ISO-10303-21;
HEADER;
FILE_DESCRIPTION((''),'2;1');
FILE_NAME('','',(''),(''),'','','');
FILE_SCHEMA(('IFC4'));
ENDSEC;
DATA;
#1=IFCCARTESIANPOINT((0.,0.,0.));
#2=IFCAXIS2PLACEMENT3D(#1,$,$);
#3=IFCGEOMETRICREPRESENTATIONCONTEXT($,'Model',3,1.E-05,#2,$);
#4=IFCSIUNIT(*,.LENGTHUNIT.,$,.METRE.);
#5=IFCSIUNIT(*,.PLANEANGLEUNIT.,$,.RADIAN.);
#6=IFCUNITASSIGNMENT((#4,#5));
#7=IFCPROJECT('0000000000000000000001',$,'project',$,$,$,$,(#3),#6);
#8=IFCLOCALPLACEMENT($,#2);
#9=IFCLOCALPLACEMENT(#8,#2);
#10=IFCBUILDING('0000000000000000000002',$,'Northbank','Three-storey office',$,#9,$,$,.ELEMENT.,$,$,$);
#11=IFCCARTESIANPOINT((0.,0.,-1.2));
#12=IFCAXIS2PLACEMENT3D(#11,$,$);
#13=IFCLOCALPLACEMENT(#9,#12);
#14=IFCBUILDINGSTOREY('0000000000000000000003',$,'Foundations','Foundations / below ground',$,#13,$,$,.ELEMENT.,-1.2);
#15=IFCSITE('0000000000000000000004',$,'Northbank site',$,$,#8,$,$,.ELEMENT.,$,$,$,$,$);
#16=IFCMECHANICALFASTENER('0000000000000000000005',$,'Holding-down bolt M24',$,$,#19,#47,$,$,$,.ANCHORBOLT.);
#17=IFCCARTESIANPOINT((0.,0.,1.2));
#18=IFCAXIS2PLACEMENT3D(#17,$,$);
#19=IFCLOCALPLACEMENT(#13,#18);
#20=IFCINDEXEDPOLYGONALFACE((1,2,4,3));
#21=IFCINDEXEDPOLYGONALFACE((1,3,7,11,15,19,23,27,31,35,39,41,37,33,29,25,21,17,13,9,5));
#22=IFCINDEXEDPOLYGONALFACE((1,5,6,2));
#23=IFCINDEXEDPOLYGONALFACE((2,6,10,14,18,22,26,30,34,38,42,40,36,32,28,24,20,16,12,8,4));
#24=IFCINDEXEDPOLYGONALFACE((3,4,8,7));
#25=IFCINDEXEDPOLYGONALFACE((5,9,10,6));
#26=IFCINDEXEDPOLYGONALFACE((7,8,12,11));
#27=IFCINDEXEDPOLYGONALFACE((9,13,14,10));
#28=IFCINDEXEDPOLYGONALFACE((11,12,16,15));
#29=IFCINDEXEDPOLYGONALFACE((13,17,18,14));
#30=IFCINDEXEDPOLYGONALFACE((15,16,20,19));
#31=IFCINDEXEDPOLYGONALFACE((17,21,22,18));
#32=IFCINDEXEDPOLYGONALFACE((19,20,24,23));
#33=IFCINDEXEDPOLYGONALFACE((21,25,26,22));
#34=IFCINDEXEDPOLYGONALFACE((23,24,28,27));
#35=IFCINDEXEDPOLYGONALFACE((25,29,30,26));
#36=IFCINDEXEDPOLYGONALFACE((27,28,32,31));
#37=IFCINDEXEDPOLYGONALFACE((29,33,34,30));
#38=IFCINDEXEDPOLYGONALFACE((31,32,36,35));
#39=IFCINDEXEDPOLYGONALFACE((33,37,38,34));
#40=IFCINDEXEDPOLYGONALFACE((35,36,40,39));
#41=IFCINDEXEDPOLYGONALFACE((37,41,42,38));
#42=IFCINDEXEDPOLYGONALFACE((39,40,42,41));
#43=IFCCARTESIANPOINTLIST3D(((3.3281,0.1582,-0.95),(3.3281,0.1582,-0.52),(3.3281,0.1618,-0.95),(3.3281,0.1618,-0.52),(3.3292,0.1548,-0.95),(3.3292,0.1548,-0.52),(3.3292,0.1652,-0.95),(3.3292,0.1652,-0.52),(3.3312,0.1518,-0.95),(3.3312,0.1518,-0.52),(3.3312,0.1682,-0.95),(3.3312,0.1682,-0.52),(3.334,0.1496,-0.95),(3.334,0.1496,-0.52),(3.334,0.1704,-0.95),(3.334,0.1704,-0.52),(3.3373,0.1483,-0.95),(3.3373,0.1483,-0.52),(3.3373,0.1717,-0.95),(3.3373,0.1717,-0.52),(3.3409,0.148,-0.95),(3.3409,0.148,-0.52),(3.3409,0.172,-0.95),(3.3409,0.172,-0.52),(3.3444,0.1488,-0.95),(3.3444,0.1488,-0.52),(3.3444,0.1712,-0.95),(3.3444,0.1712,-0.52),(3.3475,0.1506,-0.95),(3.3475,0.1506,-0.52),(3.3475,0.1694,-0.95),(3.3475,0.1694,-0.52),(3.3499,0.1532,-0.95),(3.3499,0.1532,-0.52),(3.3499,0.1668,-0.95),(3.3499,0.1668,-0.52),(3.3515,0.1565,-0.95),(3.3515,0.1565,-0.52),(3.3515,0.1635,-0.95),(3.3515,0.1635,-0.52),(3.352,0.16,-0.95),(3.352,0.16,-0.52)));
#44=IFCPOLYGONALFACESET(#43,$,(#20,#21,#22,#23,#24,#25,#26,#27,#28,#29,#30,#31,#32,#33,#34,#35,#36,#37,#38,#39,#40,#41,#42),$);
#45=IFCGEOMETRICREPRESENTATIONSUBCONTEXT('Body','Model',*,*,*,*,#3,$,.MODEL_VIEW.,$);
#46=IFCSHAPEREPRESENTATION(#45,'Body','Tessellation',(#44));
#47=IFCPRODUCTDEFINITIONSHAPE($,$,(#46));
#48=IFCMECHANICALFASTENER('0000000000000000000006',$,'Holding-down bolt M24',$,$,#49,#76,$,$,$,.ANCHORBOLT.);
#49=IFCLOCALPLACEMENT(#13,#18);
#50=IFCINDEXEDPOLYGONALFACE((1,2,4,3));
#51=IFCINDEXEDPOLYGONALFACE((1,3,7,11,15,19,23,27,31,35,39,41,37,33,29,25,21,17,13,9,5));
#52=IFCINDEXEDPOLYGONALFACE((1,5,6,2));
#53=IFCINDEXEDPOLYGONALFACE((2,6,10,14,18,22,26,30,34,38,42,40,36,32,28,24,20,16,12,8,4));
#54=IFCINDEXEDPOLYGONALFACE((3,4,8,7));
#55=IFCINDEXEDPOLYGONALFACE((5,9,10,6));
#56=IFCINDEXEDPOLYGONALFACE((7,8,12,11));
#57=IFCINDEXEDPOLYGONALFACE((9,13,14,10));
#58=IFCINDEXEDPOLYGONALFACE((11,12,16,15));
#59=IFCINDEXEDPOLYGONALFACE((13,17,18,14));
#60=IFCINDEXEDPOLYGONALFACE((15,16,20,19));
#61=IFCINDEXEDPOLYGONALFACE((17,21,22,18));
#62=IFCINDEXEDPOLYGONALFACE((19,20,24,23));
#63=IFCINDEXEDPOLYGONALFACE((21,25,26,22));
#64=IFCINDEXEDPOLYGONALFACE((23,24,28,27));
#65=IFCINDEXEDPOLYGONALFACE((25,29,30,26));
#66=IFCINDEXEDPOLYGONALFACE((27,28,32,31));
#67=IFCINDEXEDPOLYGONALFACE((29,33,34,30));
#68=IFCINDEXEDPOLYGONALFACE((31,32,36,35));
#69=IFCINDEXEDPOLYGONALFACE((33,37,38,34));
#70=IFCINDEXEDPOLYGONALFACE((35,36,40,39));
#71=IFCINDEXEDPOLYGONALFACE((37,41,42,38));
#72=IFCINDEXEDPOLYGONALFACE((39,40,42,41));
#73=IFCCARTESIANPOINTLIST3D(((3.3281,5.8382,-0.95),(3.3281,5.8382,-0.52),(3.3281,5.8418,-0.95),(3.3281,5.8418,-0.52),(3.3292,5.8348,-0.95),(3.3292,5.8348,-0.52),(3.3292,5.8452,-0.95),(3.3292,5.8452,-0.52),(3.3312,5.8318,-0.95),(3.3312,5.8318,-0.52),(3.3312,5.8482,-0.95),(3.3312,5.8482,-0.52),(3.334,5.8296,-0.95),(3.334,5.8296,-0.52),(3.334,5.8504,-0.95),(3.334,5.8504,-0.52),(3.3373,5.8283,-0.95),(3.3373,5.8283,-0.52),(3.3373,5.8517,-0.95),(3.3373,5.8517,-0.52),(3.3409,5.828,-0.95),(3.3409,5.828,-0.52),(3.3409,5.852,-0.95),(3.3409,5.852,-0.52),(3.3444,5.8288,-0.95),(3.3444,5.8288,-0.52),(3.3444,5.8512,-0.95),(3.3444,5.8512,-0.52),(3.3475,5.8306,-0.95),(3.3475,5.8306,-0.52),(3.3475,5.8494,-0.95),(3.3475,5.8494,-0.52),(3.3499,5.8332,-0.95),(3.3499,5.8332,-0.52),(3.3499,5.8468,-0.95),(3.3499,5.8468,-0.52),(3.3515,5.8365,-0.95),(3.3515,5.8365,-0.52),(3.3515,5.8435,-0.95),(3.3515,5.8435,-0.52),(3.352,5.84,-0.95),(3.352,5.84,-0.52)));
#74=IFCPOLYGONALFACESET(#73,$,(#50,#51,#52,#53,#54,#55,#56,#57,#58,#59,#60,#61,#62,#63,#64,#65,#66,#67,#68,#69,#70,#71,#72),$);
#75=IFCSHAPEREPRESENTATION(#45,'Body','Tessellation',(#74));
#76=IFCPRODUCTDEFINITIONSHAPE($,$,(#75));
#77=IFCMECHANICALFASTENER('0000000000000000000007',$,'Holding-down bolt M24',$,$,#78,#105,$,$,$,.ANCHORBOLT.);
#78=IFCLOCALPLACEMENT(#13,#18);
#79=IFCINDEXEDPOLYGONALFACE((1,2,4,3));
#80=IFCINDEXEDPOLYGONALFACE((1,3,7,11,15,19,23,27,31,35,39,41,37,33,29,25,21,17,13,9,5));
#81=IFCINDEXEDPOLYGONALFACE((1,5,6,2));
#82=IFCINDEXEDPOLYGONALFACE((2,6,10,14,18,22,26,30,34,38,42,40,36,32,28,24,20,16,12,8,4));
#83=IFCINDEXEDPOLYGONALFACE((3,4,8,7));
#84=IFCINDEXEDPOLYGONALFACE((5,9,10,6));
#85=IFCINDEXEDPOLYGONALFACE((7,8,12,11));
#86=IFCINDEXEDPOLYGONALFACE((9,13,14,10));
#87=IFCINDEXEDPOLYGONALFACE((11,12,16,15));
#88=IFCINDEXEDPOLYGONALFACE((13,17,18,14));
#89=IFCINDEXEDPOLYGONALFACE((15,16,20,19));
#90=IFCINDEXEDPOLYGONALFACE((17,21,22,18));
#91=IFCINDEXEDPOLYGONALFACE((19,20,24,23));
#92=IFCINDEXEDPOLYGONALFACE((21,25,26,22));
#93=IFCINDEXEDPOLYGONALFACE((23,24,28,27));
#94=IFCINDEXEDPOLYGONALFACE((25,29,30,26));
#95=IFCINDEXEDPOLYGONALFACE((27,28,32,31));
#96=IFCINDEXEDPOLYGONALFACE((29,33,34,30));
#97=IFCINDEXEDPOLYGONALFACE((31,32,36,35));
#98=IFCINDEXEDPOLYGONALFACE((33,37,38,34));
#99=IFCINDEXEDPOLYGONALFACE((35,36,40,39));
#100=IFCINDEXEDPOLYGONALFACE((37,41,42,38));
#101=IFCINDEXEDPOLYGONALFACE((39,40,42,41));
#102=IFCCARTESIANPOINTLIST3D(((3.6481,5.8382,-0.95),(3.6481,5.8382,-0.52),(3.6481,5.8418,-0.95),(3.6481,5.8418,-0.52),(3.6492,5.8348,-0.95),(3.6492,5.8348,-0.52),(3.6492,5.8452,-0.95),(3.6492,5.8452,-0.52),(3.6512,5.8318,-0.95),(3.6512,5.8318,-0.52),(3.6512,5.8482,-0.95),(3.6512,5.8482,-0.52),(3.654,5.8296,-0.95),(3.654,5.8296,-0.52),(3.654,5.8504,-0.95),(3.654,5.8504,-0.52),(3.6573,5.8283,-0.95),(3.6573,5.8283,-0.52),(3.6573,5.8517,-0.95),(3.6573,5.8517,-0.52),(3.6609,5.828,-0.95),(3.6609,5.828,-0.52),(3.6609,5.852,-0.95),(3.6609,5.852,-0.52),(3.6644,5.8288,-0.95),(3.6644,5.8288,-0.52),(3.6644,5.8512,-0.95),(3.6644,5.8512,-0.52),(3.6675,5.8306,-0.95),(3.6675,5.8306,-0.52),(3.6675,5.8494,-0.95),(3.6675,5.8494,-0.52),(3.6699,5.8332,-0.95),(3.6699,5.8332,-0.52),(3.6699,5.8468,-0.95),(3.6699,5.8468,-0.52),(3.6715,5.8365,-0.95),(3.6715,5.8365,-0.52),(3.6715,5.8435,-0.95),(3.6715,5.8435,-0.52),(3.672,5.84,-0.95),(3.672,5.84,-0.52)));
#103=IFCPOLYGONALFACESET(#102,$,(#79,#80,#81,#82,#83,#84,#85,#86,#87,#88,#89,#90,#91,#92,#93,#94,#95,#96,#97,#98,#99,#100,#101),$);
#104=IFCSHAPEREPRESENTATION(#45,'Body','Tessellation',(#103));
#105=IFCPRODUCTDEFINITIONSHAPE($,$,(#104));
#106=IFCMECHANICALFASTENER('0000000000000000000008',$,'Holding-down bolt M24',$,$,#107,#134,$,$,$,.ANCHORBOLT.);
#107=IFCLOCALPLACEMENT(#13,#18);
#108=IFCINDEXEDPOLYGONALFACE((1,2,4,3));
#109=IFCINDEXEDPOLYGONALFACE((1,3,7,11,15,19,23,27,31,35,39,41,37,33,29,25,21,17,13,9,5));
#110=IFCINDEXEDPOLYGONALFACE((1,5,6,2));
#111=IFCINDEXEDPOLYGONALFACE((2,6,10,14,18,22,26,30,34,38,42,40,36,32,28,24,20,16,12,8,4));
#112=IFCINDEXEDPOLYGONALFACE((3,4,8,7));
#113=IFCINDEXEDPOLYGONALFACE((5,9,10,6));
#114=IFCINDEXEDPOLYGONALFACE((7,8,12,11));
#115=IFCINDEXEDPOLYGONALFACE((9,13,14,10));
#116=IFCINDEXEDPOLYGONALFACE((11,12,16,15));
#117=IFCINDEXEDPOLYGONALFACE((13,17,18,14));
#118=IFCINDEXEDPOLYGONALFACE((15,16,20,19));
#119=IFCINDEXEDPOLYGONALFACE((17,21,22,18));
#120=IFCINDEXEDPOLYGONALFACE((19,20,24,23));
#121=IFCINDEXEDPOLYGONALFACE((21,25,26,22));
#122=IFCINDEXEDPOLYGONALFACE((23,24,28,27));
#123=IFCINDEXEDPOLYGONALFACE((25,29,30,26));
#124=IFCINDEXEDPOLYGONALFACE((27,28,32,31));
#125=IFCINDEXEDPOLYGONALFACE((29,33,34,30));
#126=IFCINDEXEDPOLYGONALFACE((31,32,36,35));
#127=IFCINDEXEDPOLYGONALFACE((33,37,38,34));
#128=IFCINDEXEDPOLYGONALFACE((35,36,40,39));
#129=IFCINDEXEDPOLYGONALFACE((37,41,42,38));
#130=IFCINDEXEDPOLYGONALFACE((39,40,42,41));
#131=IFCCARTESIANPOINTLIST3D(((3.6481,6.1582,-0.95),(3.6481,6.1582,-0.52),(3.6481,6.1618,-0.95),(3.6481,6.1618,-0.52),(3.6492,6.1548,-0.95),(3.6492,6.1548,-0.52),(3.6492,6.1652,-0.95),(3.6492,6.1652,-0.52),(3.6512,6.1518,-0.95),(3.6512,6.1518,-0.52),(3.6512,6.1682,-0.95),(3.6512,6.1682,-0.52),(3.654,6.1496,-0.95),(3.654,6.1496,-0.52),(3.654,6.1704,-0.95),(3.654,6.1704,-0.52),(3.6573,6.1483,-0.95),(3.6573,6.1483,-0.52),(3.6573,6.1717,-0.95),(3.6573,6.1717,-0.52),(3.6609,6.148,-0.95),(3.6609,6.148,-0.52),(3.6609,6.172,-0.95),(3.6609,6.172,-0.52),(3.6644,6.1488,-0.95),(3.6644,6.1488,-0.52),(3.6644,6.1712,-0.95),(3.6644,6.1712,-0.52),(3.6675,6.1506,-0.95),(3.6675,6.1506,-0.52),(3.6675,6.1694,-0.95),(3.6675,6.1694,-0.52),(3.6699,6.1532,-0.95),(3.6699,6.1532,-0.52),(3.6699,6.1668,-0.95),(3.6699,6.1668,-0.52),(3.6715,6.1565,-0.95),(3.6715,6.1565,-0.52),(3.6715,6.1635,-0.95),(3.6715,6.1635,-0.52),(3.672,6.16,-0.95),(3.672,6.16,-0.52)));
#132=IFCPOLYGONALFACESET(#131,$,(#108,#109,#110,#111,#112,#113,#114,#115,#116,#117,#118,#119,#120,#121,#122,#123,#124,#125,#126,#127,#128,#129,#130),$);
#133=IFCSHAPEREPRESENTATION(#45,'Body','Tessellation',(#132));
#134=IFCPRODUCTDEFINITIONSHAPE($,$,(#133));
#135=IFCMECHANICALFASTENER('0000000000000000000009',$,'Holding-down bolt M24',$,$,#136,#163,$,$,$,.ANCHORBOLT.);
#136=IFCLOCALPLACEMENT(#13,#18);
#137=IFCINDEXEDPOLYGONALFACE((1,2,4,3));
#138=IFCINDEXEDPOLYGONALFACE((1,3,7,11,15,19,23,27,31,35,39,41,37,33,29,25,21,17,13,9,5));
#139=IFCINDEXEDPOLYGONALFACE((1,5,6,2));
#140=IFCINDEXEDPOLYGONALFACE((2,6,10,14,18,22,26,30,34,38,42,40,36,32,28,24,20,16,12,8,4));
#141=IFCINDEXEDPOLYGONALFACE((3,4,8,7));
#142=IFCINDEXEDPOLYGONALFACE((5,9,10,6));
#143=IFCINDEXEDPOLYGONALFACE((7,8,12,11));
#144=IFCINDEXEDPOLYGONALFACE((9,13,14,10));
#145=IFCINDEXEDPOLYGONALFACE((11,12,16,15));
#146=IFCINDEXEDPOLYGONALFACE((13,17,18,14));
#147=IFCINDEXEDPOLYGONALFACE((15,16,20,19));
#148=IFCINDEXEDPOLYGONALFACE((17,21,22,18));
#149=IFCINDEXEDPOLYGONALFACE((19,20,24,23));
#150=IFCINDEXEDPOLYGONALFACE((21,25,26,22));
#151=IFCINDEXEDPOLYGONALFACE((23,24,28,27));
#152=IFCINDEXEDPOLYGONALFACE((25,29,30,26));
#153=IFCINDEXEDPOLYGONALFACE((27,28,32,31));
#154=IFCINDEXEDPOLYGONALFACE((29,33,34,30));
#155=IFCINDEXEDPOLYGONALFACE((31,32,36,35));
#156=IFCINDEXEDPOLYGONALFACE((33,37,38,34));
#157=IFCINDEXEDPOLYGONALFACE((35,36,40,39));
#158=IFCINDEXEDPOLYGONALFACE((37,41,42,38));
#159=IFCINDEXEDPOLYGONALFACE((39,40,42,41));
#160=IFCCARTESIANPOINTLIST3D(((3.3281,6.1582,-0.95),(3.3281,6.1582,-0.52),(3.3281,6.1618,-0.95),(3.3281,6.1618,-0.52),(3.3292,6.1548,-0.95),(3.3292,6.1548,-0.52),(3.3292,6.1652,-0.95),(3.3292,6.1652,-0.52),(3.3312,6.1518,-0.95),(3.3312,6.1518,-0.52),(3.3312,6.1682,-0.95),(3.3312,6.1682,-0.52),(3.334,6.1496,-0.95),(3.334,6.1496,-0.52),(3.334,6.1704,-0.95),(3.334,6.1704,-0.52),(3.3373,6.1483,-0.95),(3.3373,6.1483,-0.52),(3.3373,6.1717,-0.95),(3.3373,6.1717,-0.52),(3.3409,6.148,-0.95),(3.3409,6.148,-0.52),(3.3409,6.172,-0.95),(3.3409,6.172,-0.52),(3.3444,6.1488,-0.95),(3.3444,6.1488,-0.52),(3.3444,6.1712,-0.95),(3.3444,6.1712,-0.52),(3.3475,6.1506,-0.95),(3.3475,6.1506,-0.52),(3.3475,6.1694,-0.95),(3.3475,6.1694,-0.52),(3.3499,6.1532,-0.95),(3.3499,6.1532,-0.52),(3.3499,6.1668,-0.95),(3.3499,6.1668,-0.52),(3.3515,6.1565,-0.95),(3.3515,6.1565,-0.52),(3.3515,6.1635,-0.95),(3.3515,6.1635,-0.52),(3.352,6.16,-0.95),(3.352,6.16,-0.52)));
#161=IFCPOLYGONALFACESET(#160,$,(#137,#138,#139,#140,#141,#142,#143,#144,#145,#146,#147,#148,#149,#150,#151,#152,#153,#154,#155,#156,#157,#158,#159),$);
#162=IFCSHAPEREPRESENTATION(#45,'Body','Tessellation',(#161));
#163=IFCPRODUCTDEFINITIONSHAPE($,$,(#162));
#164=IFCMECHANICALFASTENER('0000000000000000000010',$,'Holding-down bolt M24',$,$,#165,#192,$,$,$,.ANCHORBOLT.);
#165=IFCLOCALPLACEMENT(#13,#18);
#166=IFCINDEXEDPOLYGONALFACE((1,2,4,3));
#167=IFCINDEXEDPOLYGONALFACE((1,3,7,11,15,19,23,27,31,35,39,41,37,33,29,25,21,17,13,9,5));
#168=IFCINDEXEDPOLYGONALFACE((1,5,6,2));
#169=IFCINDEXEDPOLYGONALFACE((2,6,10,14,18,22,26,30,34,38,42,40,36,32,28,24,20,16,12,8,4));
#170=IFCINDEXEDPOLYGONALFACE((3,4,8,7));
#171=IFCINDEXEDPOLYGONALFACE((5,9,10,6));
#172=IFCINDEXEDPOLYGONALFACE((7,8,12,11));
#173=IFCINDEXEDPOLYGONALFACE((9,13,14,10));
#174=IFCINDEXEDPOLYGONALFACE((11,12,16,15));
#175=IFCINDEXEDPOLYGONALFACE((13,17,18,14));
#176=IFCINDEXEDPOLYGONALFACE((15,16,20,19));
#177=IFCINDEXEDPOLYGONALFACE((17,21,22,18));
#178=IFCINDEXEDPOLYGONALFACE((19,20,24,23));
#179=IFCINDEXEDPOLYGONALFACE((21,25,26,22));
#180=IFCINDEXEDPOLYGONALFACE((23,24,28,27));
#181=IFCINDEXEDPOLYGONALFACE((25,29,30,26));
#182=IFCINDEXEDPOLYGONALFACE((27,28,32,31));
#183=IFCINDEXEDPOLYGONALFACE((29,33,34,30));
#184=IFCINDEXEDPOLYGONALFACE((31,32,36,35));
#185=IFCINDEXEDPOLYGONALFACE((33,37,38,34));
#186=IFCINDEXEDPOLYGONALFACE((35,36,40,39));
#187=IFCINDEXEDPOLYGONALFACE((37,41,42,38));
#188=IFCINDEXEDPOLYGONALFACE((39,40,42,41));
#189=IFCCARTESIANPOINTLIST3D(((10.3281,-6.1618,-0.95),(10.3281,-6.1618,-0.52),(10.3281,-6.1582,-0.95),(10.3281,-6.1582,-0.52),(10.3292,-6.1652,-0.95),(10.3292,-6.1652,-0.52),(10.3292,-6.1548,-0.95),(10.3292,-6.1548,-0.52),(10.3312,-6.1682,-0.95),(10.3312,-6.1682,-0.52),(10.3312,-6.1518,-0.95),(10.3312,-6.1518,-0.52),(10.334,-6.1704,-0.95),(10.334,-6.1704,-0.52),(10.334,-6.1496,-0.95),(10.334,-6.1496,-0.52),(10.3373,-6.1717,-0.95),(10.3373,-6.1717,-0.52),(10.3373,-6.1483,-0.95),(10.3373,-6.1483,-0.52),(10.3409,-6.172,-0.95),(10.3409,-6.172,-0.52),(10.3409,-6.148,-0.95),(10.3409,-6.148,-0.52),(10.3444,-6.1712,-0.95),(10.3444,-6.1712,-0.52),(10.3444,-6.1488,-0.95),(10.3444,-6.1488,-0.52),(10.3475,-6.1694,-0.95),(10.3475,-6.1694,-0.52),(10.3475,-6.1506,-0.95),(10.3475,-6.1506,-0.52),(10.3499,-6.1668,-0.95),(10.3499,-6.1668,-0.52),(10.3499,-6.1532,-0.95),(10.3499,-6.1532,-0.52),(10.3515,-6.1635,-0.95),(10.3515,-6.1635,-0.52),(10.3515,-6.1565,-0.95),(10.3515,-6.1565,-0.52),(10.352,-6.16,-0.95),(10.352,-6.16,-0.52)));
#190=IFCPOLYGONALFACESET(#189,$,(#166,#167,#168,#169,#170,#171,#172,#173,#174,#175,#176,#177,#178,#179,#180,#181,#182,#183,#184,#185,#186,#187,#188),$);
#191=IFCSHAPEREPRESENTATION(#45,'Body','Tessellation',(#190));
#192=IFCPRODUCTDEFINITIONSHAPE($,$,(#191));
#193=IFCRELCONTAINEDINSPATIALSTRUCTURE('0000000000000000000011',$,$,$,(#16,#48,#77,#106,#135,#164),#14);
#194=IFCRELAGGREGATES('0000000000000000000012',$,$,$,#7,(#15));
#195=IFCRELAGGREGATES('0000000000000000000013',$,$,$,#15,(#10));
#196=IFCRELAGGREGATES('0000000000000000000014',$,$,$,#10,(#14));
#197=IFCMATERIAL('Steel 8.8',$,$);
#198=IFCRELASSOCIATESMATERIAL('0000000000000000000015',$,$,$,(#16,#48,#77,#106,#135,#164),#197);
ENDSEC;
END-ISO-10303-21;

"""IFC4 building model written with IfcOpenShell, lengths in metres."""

from ifc_helpers import new_model, si_unit, frame, origin, place, context, subcontext, project, spatial, circle, extrude, material, element, save


model = new_model("IFC4")

# Units and contexts
model_context = context("Model", 3, precision=1e-05, world=origin())
body_context = subcontext(model_context, "Body", "Model", "MODEL_VIEW")
ifc_project = project(units=[si_unit("LENGTHUNIT", "METRE"), si_unit("PLANEANGLEUNIT", "RADIAN")], contexts=[model_context])

# Site, building, storey
site_placement = place(None, origin())
site = spatial("IfcSite", under=ifc_project, at=site_placement, Name="Northbank site", CompositionType="ELEMENT")
building_placement = place(site_placement, origin())
building = spatial("IfcBuilding", under=site, at=building_placement, Name="Northbank", Description="Three-storey office", CompositionType="ELEMENT")
storey_placement = place(building_placement, frame((0.0, 0.0, -1.2)))
storey = spatial("IfcBuildingStorey", under=building, at=storey_placement, Name="Foundations", Description="Foundations / below ground", CompositionType="ELEMENT", Elevation=-1.2)

# Mechanical fasteners
ifc_material_1 = material(Name="Steel 8.8")
mechanical_fastener_1_placement = place(storey_placement, frame((0.0, 0.0, 1.2)))
element("IfcMechanicalFastener", 1, at=mechanical_fastener_1_placement, inside=storey, material=ifc_material_1, Name="Holding-down bolt M24", PredefinedType="ANCHORBOLT", context=body_context, shape_type="SweptSolid", body=[
    extrude(circle(Radius=0.012), frame((3.34, 0.16, -0.95), z_axis=(0.0, 0.0, 1.0), x_axis=(1.0, 0.0, 0.0)), (0.0, 0.0, 1.0), 0.43),
])
mechanical_fastener_2_placement = place(storey_placement, frame((0.0, 0.0, 1.2)))
element("IfcMechanicalFastener", 2, at=mechanical_fastener_2_placement, inside=storey, material=ifc_material_1, Name="Holding-down bolt M24", PredefinedType="ANCHORBOLT", context=body_context, shape_type="SweptSolid", body=[
    extrude(circle(Radius=0.012), frame((3.34, 5.84, -0.95), z_axis=(0.0, 0.0, 1.0), x_axis=(1.0, 0.0, 0.0)), (0.0, 0.0, 1.0), 0.43),
])
mechanical_fastener_3_placement = place(storey_placement, frame((0.0, 0.0, 1.2)))
element("IfcMechanicalFastener", 3, at=mechanical_fastener_3_placement, inside=storey, material=ifc_material_1, Name="Holding-down bolt M24", PredefinedType="ANCHORBOLT", context=body_context, shape_type="SweptSolid", body=[
    extrude(circle(Radius=0.012), frame((3.66, 5.84, -0.95), z_axis=(0.0, 0.0, 1.0), x_axis=(1.0, 0.0, 0.0)), (0.0, 0.0, 1.0), 0.43),
])
mechanical_fastener_4_placement = place(storey_placement, frame((0.0, 0.0, 1.2)))
element("IfcMechanicalFastener", 4, at=mechanical_fastener_4_placement, inside=storey, material=ifc_material_1, Name="Holding-down bolt M24", PredefinedType="ANCHORBOLT", context=body_context, shape_type="SweptSolid", body=[
    extrude(circle(Radius=0.012), frame((3.66, 6.16, -0.95), z_axis=(0.0, 0.0, 1.0), x_axis=(1.0, 0.0, 0.0)), (0.0, 0.0, 1.0), 0.43),
])
mechanical_fastener_5_placement = place(storey_placement, frame((0.0, 0.0, 1.2)))
element("IfcMechanicalFastener", 5, at=mechanical_fastener_5_placement, inside=storey, material=ifc_material_1, Name="Holding-down bolt M24", PredefinedType="ANCHORBOLT", context=body_context, shape_type="SweptSolid", body=[
    extrude(circle(Radius=0.012), frame((3.34, 6.16, -0.95), z_axis=(0.0, 0.0, 1.0), x_axis=(1.0, 0.0, 0.0)), (0.0, 0.0, 1.0), 0.43),
])
mechanical_fastener_6_placement = place(storey_placement, frame((0.0, 0.0, 1.2)))
element("IfcMechanicalFastener", 6, at=mechanical_fastener_6_placement, inside=storey, material=ifc_material_1, Name="Holding-down bolt M24", PredefinedType="ANCHORBOLT", context=body_context, shape_type="SweptSolid", body=[
    extrude(circle(Radius=0.012), frame((10.34, -6.16, -0.95), z_axis=(0.0, 0.0, 1.0), x_axis=(1.0, 0.0, 0.0)), (0.0, 0.0, 1.0), 0.43),
])

save(model, "model.ifc")
